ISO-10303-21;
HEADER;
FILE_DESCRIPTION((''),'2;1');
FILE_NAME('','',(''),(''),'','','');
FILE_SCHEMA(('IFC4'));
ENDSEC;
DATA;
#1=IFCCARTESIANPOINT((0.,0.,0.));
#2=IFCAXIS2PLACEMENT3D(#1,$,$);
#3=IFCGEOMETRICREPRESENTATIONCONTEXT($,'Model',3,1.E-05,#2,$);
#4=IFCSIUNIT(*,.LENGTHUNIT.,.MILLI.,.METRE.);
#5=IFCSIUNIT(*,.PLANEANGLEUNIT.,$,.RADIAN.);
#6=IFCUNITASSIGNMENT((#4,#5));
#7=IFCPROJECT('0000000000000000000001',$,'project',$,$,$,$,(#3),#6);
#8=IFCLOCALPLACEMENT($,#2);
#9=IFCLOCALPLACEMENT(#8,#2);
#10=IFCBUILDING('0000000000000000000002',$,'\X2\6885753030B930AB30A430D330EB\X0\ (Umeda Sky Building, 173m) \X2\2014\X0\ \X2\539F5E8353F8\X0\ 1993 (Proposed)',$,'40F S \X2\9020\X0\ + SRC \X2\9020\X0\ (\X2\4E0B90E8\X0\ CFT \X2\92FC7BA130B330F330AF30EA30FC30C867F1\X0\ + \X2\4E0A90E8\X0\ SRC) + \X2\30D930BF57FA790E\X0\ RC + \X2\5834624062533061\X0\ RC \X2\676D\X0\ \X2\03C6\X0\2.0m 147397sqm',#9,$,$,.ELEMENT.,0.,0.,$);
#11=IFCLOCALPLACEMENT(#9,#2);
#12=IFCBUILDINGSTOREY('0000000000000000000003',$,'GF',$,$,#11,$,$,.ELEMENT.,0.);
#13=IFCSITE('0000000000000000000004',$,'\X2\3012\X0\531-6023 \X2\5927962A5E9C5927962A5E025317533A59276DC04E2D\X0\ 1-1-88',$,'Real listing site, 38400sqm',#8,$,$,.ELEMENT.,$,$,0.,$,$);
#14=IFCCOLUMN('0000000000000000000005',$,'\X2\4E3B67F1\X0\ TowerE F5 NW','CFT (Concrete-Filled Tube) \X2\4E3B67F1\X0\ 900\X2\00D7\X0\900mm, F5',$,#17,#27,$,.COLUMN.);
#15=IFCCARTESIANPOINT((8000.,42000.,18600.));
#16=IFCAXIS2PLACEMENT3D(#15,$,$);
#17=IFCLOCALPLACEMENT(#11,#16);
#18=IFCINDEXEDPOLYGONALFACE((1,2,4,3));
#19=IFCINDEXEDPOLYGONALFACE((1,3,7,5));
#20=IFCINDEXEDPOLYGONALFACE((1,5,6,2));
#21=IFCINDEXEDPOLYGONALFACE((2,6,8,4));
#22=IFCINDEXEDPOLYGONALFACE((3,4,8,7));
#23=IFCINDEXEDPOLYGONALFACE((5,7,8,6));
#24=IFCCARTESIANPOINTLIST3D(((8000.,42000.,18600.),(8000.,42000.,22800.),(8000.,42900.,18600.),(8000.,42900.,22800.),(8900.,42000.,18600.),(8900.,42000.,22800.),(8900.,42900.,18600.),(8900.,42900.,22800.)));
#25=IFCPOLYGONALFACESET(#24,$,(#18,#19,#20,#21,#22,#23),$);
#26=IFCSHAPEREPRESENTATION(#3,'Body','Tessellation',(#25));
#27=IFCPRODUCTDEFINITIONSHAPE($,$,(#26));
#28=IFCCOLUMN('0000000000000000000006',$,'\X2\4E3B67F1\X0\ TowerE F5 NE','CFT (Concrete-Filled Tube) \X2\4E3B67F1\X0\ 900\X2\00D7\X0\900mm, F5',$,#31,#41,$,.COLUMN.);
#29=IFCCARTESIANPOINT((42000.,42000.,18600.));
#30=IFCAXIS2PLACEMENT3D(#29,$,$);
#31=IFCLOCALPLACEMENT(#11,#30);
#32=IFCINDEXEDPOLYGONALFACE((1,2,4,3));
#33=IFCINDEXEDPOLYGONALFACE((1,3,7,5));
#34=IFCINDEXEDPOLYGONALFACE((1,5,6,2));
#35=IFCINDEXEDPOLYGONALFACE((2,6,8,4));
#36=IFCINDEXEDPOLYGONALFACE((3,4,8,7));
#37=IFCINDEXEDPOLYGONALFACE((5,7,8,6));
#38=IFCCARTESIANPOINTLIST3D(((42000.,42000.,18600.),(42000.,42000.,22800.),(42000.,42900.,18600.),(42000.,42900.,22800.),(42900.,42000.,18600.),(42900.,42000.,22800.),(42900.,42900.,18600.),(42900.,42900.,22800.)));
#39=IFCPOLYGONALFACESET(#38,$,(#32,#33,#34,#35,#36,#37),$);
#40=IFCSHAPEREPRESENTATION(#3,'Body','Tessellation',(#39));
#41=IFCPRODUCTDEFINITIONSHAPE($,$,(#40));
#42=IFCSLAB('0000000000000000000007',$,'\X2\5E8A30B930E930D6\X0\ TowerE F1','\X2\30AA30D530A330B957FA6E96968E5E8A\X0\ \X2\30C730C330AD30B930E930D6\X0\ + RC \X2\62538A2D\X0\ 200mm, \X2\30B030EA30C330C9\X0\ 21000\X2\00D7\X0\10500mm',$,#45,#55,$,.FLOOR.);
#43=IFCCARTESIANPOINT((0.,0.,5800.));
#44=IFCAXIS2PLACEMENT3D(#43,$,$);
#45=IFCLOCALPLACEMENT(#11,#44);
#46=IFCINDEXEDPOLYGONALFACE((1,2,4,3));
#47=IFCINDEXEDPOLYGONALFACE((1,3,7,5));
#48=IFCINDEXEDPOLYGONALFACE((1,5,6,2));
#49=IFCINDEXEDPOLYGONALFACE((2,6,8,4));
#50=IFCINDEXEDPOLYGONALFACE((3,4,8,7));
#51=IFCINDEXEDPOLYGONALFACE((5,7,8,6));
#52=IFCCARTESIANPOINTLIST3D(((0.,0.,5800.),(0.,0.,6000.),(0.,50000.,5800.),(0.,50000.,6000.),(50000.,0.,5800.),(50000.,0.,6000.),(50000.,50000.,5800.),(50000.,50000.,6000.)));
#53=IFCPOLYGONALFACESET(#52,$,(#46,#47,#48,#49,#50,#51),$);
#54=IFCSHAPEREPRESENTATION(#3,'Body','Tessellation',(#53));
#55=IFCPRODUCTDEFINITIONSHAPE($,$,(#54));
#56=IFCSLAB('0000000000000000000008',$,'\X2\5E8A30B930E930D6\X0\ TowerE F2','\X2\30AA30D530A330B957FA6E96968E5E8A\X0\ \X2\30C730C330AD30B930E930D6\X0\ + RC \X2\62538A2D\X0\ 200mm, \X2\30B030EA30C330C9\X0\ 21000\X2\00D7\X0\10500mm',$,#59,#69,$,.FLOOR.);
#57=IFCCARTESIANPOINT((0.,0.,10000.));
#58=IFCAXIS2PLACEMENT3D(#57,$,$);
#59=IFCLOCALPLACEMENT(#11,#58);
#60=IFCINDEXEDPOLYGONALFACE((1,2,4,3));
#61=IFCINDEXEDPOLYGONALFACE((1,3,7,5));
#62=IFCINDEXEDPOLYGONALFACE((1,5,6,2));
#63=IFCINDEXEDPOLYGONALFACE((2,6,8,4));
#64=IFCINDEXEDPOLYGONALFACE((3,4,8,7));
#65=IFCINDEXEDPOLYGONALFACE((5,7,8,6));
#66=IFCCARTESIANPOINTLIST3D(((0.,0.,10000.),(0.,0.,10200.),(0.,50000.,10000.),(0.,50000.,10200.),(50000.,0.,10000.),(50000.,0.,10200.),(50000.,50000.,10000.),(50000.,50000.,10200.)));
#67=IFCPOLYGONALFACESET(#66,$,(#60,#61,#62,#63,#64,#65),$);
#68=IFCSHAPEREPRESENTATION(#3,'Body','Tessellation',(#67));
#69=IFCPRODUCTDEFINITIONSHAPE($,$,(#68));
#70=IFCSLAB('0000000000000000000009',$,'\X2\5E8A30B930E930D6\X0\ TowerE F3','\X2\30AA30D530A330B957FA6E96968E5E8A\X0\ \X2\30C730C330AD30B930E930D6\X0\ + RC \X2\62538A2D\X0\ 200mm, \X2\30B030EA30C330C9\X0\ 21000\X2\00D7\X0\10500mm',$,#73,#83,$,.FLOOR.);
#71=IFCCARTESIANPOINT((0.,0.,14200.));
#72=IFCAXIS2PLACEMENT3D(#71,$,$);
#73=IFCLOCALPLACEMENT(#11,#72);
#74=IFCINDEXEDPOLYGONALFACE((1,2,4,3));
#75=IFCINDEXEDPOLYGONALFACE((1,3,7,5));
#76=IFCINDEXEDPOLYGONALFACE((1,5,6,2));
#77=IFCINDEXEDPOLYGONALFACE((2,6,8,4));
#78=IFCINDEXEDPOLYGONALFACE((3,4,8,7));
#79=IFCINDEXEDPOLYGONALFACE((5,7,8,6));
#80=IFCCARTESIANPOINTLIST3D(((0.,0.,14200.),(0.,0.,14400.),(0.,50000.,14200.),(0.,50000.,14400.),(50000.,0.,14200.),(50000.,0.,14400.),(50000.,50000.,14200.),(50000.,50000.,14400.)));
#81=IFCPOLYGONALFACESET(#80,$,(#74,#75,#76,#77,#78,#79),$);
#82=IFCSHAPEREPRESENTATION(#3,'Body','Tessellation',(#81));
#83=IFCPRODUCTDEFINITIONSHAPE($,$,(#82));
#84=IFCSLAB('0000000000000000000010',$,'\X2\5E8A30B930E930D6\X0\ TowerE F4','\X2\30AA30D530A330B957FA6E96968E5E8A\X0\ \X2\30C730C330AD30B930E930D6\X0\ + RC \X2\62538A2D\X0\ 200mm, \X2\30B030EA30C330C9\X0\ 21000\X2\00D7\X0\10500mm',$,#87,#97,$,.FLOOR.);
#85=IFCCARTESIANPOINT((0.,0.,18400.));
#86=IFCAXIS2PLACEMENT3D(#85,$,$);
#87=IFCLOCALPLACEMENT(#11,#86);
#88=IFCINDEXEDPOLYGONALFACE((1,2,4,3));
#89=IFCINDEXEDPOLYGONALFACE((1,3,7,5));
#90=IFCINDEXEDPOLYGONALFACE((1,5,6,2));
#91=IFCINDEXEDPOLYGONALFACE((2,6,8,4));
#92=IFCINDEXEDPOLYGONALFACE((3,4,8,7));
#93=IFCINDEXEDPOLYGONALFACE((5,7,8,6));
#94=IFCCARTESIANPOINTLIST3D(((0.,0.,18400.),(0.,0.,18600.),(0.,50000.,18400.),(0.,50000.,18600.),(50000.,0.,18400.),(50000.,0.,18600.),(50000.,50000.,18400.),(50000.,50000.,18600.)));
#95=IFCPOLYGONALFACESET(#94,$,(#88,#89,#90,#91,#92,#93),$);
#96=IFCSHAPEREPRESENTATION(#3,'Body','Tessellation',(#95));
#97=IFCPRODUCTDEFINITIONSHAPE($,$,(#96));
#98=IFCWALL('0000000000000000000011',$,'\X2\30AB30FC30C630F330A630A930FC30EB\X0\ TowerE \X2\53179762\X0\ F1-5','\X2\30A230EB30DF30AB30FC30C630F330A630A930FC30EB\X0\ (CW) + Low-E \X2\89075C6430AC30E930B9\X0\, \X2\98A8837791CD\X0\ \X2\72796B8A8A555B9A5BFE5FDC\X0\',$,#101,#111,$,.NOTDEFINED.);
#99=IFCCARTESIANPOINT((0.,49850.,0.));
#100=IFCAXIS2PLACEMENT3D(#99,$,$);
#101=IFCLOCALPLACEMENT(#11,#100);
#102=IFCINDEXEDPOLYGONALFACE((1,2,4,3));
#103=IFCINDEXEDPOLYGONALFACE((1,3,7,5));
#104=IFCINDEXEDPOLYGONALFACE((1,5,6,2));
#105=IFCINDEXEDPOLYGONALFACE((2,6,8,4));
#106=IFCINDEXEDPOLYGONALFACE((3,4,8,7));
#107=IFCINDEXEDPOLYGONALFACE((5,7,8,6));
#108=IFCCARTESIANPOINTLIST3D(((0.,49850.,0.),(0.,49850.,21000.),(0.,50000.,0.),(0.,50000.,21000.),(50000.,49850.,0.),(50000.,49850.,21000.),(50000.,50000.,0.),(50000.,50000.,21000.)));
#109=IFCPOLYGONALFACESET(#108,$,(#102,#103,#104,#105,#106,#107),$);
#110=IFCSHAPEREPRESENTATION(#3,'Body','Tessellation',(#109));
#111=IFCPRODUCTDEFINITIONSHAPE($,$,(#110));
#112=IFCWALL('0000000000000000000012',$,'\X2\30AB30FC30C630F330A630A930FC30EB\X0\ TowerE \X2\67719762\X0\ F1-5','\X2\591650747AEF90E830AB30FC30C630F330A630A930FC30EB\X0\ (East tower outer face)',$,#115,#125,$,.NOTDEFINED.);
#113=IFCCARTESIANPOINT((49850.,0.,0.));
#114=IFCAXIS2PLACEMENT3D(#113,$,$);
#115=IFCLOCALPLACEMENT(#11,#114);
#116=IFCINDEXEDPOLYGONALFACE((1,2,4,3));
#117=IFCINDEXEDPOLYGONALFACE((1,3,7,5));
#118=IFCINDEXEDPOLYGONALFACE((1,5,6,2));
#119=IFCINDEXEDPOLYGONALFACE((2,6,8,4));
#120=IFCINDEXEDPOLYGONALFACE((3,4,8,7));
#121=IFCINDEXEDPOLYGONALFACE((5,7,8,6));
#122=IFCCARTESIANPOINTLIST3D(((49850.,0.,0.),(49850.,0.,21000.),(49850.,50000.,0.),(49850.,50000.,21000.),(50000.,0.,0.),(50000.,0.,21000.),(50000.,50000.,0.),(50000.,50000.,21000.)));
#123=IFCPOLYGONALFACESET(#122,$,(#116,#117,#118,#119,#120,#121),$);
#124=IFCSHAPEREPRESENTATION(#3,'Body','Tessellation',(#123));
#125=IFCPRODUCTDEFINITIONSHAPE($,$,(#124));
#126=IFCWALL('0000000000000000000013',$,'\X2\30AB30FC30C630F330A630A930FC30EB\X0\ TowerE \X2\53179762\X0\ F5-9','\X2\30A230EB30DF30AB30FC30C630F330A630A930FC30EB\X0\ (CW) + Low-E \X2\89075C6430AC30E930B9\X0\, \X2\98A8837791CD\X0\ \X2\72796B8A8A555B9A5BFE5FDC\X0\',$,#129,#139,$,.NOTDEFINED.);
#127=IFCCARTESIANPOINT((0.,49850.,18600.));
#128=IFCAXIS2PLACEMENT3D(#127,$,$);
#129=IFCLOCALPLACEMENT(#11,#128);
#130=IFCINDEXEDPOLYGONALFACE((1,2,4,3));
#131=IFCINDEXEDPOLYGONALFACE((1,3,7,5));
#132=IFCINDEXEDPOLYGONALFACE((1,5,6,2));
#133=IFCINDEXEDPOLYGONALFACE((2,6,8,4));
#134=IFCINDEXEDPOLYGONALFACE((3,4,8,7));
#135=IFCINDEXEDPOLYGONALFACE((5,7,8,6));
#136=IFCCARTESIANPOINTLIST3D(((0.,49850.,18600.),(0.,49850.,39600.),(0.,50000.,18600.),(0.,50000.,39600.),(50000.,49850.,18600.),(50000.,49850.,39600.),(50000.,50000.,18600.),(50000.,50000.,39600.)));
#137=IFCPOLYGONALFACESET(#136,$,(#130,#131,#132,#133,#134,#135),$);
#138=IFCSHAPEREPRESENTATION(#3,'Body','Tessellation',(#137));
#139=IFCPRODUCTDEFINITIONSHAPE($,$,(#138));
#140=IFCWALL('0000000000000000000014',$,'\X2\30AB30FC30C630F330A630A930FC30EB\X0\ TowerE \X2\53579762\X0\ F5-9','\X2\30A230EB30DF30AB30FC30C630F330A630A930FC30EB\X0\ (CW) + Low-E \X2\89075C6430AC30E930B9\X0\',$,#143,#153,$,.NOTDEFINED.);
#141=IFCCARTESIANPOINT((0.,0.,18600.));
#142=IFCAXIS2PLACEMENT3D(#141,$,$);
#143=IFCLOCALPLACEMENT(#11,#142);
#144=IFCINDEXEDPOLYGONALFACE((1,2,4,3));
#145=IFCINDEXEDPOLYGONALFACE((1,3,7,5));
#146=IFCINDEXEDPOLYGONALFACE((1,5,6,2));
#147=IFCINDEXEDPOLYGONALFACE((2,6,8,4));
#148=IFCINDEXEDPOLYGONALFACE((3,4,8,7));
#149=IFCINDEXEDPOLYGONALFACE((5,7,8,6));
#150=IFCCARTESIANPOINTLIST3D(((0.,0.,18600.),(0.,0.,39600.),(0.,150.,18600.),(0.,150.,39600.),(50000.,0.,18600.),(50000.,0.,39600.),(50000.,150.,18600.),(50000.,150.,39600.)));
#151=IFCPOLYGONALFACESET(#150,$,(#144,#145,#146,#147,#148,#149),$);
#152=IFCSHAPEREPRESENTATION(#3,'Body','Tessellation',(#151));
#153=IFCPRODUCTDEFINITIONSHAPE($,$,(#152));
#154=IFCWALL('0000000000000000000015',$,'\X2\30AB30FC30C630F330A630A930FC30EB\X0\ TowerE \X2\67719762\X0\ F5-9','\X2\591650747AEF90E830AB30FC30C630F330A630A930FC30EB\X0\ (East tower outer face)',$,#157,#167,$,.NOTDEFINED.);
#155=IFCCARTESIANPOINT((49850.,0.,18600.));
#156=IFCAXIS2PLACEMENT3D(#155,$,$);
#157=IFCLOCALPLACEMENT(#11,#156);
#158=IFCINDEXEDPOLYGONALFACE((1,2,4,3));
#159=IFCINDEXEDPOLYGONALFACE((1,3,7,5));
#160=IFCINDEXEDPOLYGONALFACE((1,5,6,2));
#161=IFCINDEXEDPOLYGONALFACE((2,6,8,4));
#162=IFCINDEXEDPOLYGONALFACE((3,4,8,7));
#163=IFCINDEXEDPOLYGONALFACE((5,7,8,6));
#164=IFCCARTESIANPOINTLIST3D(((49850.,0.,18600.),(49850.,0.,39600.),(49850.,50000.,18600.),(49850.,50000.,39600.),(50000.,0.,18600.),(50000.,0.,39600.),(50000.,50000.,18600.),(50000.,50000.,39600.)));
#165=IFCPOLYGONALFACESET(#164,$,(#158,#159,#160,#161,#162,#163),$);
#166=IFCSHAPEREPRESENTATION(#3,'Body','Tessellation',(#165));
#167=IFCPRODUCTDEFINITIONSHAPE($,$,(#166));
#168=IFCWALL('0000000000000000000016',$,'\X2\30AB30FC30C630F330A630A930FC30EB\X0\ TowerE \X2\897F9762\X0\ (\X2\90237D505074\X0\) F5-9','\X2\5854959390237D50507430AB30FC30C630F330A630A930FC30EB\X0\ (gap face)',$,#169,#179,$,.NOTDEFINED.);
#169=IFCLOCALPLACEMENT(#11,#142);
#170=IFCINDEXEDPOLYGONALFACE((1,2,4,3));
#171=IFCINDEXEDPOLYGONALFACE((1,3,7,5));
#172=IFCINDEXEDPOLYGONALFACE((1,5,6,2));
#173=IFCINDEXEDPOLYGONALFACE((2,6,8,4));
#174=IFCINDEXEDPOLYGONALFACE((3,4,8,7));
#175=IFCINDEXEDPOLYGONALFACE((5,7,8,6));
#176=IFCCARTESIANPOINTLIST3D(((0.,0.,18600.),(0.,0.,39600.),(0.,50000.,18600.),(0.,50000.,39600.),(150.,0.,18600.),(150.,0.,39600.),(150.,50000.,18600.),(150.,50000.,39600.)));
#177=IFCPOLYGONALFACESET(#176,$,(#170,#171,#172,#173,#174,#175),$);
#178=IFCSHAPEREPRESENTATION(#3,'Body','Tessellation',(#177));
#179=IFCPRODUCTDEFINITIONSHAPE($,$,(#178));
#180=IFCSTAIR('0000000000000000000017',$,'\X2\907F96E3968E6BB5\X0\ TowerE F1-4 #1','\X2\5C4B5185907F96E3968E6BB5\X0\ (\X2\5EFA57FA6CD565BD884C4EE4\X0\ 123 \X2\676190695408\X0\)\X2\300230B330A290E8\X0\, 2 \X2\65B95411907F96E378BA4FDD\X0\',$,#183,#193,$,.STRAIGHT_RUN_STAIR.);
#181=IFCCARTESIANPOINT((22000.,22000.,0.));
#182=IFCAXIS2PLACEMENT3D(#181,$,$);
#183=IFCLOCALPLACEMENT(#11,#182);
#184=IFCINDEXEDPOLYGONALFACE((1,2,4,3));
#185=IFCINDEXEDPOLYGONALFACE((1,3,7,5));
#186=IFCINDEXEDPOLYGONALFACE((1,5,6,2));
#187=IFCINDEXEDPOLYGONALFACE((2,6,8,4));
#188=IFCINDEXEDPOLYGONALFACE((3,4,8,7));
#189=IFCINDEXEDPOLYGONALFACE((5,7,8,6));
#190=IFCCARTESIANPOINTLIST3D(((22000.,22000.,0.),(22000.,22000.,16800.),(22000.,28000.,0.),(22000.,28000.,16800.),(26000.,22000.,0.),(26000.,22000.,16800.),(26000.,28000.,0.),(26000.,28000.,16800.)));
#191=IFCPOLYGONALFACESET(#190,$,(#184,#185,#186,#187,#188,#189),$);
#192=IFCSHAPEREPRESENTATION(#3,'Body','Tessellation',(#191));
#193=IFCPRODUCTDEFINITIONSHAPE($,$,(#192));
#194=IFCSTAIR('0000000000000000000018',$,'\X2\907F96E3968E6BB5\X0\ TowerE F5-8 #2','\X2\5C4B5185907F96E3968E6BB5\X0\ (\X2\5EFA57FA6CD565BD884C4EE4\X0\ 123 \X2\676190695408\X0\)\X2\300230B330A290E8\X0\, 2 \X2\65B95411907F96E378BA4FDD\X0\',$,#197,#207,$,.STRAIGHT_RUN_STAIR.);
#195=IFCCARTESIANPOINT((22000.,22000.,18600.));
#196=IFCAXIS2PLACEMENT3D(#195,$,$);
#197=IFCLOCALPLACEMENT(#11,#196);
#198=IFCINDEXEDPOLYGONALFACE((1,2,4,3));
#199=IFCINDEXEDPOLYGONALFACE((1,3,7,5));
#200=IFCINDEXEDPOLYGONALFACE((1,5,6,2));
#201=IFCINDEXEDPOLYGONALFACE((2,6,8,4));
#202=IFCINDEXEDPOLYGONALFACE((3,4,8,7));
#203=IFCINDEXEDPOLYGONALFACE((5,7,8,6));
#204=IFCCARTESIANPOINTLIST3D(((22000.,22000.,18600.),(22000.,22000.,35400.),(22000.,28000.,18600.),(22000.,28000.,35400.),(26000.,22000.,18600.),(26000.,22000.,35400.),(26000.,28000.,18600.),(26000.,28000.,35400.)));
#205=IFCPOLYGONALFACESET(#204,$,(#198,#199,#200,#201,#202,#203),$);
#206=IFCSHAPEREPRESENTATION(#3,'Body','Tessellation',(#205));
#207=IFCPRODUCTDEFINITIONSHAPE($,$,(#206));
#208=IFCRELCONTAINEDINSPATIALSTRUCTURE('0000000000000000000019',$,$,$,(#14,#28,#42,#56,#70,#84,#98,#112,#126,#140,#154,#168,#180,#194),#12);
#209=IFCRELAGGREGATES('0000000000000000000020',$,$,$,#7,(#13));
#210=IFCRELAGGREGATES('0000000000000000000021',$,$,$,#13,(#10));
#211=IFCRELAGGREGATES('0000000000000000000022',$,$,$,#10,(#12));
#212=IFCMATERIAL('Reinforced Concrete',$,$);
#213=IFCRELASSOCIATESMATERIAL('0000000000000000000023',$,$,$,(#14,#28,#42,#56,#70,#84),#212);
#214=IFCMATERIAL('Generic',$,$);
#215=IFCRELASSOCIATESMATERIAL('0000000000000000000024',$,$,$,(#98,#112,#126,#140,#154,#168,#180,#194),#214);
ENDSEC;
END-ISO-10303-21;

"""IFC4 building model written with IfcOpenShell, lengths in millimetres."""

from ifc_helpers import new_model, si_unit, frame, frame_2d, origin, place, context, project, spatial, rectangle, extrude, material, element, save


model = new_model("IFC4")

# Units and contexts
model_context = context("Model", 3, precision=1e-05, world=origin())
ifc_project = project(units=[si_unit("LENGTHUNIT", "METRE", prefix="MILLI"), si_unit("PLANEANGLEUNIT", "RADIAN")], contexts=[model_context])

# Site, building, storey
site_placement = place(None, origin())
site = spatial("IfcSite", under=ifc_project, at=site_placement, Name="〒531-6023 大阪府大阪市北区大淀中 1-1-88", ObjectType="Real listing site, 38400sqm", CompositionType="ELEMENT", RefElevation=0.0)
building_placement = place(site_placement, origin())
building = spatial("IfcBuilding", under=site, at=building_placement, Name="梅田スカイビル (Umeda Sky Building, 173m) — 原広司 1993 (Proposed)", ObjectType="40F S 造 + SRC 造 (下部 CFT 鋼管コンクリート柱 + 上部 SRC) + ベタ基礎 RC + 場所打ち RC 杭 φ2.0m 147397sqm", CompositionType="ELEMENT", ElevationOfRefHeight=0.0, ElevationOfTerrain=0.0)
storey_placement = place(building_placement, origin())
storey = spatial("IfcBuildingStorey", under=building, at=storey_placement, Name="GF", CompositionType="ELEMENT", Elevation=0.0)

# Shared definitions
ifc_material_1 = material(Name="Reinforced Concrete")

# Columns
column_1_placement = place(storey_placement, frame((8000.0, 42000.0, 18600.0)))
element("IfcColumn", 1, at=column_1_placement, inside=storey, material=ifc_material_1, Name="主柱 TowerE F5 NW", Description="CFT (Concrete-Filled Tube) 主柱 900×900mm, F5", PredefinedType="COLUMN", context=model_context, shape_type="SweptSolid", body=[
    extrude(rectangle(XDim=900.0, YDim=900.0, at=frame_2d((450.0, 450.0))), frame((8000.0, 42000.0, 18600.0)), (0.0, 0.0, 1.0), 4200.0),
])
column_2_placement = place(storey_placement, frame((42000.0, 42000.0, 18600.0)))
element("IfcColumn", 2, at=column_2_placement, inside=storey, material=ifc_material_1, Name="主柱 TowerE F5 NE", Description="CFT (Concrete-Filled Tube) 主柱 900×900mm, F5", PredefinedType="COLUMN", context=model_context, shape_type="SweptSolid", body=[
    extrude(rectangle(XDim=900.0, YDim=900.0, at=frame_2d((450.0, 450.0))), frame((42000.0, 42000.0, 18600.0)), (0.0, 0.0, 1.0), 4200.0),
])

# Slabs
slab_1_placement = place(storey_placement, frame((0.0, 0.0, 5800.0)))
element("IfcSlab", 3, at=slab_1_placement, inside=storey, material=ifc_material_1, Name="床スラブ TowerE F1", Description="オフィス基準階床 デッキスラブ + RC 打設 200mm, グリッド 21000×10500mm", PredefinedType="FLOOR", context=model_context, shape_type="SweptSolid", body=[
    extrude(rectangle(XDim=50000.0, YDim=50000.0, at=frame_2d((25000.0, 25000.0))), frame((0.0, 0.0, 5800.0)), (0.0, 0.0, 1.0), 200.0),
])
slab_2_placement = place(storey_placement, frame((0.0, 0.0, 10000.0)))
element("IfcSlab", 4, at=slab_2_placement, inside=storey, material=ifc_material_1, Name="床スラブ TowerE F2", Description="オフィス基準階床 デッキスラブ + RC 打設 200mm, グリッド 21000×10500mm", PredefinedType="FLOOR", context=model_context, shape_type="SweptSolid", body=[
    extrude(rectangle(XDim=50000.0, YDim=50000.0, at=frame_2d((25000.0, 25000.0))), frame((0.0, 0.0, 10000.0)), (0.0, 0.0, 1.0), 200.0),
])
slab_3_placement = place(storey_placement, frame((0.0, 0.0, 14200.0)))
element("IfcSlab", 5, at=slab_3_placement, inside=storey, material=ifc_material_1, Name="床スラブ TowerE F3", Description="オフィス基準階床 デッキスラブ + RC 打設 200mm, グリッド 21000×10500mm", PredefinedType="FLOOR", context=model_context, shape_type="SweptSolid", body=[
    extrude(rectangle(XDim=50000.0, YDim=50000.0, at=frame_2d((25000.0, 25000.0))), frame((0.0, 0.0, 14200.0)), (0.0, 0.0, 1.0), 200.0),
])
slab_4_placement = place(storey_placement, frame((0.0, 0.0, 18400.0)))
element("IfcSlab", 6, at=slab_4_placement, inside=storey, material=ifc_material_1, Name="床スラブ TowerE F4", Description="オフィス基準階床 デッキスラブ + RC 打設 200mm, グリッド 21000×10500mm", PredefinedType="FLOOR", context=model_context, shape_type="SweptSolid", body=[
    extrude(rectangle(XDim=50000.0, YDim=50000.0, at=frame_2d((25000.0, 25000.0))), frame((0.0, 0.0, 18400.0)), (0.0, 0.0, 1.0), 200.0),
])

# Walls
ifc_material_2 = material(Name="Generic")
wall_1_placement = place(storey_placement, frame((0.0, 49850.0, 0.0)))
element("IfcWall", 7, at=wall_1_placement, inside=storey, material=ifc_material_2, Name="カーテンウォール TowerE 北面 F1-5", Description="アルミカーテンウォール (CW) + Low-E 複層ガラス, 風荷重 特殊評定対応", PredefinedType="NOTDEFINED", context=model_context, shape_type="SweptSolid", body=[
    extrude(rectangle(XDim=50000.0, YDim=150.0, at=frame_2d((25000.0, 75.0))), frame((0.0, 49850.0, 0.0)), (0.0, 0.0, 1.0), 21000.0),
])
wall_2_placement = place(storey_placement, frame((49850.0, 0.0, 0.0)))
element("IfcWall", 8, at=wall_2_placement, inside=storey, material=ifc_material_2, Name="カーテンウォール TowerE 東面 F1-5", Description="外側端部カーテンウォール (East tower outer face)", PredefinedType="NOTDEFINED", context=model_context, shape_type="SweptSolid", body=[
    extrude(rectangle(XDim=150.0, YDim=50000.0, at=frame_2d((75.0, 25000.0))), frame((49850.0, 0.0, 0.0)), (0.0, 0.0, 1.0), 21000.0),
])
wall_3_placement = place(storey_placement, frame((0.0, 49850.0, 18600.0)))
element("IfcWall", 9, at=wall_3_placement, inside=storey, material=ifc_material_2, Name="カーテンウォール TowerE 北面 F5-9", Description="アルミカーテンウォール (CW) + Low-E 複層ガラス, 風荷重 特殊評定対応", PredefinedType="NOTDEFINED", context=model_context, shape_type="SweptSolid", body=[
    extrude(rectangle(XDim=50000.0, YDim=150.0, at=frame_2d((25000.0, 75.0))), frame((0.0, 49850.0, 18600.0)), (0.0, 0.0, 1.0), 21000.0),
])
wall_4_placement = place(storey_placement, frame((0.0, 0.0, 18600.0)))
element("IfcWall", 10, at=wall_4_placement, inside=storey, material=ifc_material_2, Name="カーテンウォール TowerE 南面 F5-9", Description="アルミカーテンウォール (CW) + Low-E 複層ガラス", PredefinedType="NOTDEFINED", context=model_context, shape_type="SweptSolid", body=[
    extrude(rectangle(XDim=50000.0, YDim=150.0, at=frame_2d((25000.0, 75.0))), frame((0.0, 0.0, 18600.0)), (0.0, 0.0, 1.0), 21000.0),
])
wall_5_placement = place(storey_placement, frame((49850.0, 0.0, 18600.0)))
element("IfcWall", 11, at=wall_5_placement, inside=storey, material=ifc_material_2, Name="カーテンウォール TowerE 東面 F5-9", Description="外側端部カーテンウォール (East tower outer face)", PredefinedType="NOTDEFINED", context=model_context, shape_type="SweptSolid", body=[
    extrude(rectangle(XDim=150.0, YDim=50000.0, at=frame_2d((75.0, 25000.0))), frame((49850.0, 0.0, 18600.0)), (0.0, 0.0, 1.0), 21000.0),
])
wall_6_placement = place(storey_placement, frame((0.0, 0.0, 18600.0)))
element("IfcWall", 12, at=wall_6_placement, inside=storey, material=ifc_material_2, Name="カーテンウォール TowerE 西面 (連結側) F5-9", Description="塔間連結側カーテンウォール (gap face)", PredefinedType="NOTDEFINED", context=model_context, shape_type="SweptSolid", body=[
    extrude(rectangle(XDim=150.0, YDim=50000.0, at=frame_2d((75.0, 25000.0))), frame((0.0, 0.0, 18600.0)), (0.0, 0.0, 1.0), 21000.0),
])

# Stairs
stair_1_placement = place(storey_placement, frame((22000.0, 22000.0, 0.0)))
element("IfcStair", 13, at=stair_1_placement, inside=storey, material=ifc_material_2, Name="避難階段 TowerE F1-4 #1", Description="屋内避難階段 (建基法施行令 123 条適合)。コア部, 2 方向避難確保", PredefinedType="STRAIGHT_RUN_STAIR", context=model_context, shape_type="SweptSolid", body=[
    extrude(rectangle(XDim=4000.0, YDim=6000.0, at=frame_2d((2000.0, 3000.0))), frame((22000.0, 22000.0, 0.0)), (0.0, 0.0, 1.0), 16800.0),
])
stair_2_placement = place(storey_placement, frame((22000.0, 22000.0, 18600.0)))
element("IfcStair", 14, at=stair_2_placement, inside=storey, material=ifc_material_2, Name="避難階段 TowerE F5-8 #2", Description="屋内避難階段 (建基法施行令 123 条適合)。コア部, 2 方向避難確保", PredefinedType="STRAIGHT_RUN_STAIR", context=model_context, shape_type="SweptSolid", body=[
    extrude(rectangle(XDim=4000.0, YDim=6000.0, at=frame_2d((2000.0, 3000.0))), frame((22000.0, 22000.0, 18600.0)), (0.0, 0.0, 1.0), 16800.0),
])

save(model, "model.ifc")
